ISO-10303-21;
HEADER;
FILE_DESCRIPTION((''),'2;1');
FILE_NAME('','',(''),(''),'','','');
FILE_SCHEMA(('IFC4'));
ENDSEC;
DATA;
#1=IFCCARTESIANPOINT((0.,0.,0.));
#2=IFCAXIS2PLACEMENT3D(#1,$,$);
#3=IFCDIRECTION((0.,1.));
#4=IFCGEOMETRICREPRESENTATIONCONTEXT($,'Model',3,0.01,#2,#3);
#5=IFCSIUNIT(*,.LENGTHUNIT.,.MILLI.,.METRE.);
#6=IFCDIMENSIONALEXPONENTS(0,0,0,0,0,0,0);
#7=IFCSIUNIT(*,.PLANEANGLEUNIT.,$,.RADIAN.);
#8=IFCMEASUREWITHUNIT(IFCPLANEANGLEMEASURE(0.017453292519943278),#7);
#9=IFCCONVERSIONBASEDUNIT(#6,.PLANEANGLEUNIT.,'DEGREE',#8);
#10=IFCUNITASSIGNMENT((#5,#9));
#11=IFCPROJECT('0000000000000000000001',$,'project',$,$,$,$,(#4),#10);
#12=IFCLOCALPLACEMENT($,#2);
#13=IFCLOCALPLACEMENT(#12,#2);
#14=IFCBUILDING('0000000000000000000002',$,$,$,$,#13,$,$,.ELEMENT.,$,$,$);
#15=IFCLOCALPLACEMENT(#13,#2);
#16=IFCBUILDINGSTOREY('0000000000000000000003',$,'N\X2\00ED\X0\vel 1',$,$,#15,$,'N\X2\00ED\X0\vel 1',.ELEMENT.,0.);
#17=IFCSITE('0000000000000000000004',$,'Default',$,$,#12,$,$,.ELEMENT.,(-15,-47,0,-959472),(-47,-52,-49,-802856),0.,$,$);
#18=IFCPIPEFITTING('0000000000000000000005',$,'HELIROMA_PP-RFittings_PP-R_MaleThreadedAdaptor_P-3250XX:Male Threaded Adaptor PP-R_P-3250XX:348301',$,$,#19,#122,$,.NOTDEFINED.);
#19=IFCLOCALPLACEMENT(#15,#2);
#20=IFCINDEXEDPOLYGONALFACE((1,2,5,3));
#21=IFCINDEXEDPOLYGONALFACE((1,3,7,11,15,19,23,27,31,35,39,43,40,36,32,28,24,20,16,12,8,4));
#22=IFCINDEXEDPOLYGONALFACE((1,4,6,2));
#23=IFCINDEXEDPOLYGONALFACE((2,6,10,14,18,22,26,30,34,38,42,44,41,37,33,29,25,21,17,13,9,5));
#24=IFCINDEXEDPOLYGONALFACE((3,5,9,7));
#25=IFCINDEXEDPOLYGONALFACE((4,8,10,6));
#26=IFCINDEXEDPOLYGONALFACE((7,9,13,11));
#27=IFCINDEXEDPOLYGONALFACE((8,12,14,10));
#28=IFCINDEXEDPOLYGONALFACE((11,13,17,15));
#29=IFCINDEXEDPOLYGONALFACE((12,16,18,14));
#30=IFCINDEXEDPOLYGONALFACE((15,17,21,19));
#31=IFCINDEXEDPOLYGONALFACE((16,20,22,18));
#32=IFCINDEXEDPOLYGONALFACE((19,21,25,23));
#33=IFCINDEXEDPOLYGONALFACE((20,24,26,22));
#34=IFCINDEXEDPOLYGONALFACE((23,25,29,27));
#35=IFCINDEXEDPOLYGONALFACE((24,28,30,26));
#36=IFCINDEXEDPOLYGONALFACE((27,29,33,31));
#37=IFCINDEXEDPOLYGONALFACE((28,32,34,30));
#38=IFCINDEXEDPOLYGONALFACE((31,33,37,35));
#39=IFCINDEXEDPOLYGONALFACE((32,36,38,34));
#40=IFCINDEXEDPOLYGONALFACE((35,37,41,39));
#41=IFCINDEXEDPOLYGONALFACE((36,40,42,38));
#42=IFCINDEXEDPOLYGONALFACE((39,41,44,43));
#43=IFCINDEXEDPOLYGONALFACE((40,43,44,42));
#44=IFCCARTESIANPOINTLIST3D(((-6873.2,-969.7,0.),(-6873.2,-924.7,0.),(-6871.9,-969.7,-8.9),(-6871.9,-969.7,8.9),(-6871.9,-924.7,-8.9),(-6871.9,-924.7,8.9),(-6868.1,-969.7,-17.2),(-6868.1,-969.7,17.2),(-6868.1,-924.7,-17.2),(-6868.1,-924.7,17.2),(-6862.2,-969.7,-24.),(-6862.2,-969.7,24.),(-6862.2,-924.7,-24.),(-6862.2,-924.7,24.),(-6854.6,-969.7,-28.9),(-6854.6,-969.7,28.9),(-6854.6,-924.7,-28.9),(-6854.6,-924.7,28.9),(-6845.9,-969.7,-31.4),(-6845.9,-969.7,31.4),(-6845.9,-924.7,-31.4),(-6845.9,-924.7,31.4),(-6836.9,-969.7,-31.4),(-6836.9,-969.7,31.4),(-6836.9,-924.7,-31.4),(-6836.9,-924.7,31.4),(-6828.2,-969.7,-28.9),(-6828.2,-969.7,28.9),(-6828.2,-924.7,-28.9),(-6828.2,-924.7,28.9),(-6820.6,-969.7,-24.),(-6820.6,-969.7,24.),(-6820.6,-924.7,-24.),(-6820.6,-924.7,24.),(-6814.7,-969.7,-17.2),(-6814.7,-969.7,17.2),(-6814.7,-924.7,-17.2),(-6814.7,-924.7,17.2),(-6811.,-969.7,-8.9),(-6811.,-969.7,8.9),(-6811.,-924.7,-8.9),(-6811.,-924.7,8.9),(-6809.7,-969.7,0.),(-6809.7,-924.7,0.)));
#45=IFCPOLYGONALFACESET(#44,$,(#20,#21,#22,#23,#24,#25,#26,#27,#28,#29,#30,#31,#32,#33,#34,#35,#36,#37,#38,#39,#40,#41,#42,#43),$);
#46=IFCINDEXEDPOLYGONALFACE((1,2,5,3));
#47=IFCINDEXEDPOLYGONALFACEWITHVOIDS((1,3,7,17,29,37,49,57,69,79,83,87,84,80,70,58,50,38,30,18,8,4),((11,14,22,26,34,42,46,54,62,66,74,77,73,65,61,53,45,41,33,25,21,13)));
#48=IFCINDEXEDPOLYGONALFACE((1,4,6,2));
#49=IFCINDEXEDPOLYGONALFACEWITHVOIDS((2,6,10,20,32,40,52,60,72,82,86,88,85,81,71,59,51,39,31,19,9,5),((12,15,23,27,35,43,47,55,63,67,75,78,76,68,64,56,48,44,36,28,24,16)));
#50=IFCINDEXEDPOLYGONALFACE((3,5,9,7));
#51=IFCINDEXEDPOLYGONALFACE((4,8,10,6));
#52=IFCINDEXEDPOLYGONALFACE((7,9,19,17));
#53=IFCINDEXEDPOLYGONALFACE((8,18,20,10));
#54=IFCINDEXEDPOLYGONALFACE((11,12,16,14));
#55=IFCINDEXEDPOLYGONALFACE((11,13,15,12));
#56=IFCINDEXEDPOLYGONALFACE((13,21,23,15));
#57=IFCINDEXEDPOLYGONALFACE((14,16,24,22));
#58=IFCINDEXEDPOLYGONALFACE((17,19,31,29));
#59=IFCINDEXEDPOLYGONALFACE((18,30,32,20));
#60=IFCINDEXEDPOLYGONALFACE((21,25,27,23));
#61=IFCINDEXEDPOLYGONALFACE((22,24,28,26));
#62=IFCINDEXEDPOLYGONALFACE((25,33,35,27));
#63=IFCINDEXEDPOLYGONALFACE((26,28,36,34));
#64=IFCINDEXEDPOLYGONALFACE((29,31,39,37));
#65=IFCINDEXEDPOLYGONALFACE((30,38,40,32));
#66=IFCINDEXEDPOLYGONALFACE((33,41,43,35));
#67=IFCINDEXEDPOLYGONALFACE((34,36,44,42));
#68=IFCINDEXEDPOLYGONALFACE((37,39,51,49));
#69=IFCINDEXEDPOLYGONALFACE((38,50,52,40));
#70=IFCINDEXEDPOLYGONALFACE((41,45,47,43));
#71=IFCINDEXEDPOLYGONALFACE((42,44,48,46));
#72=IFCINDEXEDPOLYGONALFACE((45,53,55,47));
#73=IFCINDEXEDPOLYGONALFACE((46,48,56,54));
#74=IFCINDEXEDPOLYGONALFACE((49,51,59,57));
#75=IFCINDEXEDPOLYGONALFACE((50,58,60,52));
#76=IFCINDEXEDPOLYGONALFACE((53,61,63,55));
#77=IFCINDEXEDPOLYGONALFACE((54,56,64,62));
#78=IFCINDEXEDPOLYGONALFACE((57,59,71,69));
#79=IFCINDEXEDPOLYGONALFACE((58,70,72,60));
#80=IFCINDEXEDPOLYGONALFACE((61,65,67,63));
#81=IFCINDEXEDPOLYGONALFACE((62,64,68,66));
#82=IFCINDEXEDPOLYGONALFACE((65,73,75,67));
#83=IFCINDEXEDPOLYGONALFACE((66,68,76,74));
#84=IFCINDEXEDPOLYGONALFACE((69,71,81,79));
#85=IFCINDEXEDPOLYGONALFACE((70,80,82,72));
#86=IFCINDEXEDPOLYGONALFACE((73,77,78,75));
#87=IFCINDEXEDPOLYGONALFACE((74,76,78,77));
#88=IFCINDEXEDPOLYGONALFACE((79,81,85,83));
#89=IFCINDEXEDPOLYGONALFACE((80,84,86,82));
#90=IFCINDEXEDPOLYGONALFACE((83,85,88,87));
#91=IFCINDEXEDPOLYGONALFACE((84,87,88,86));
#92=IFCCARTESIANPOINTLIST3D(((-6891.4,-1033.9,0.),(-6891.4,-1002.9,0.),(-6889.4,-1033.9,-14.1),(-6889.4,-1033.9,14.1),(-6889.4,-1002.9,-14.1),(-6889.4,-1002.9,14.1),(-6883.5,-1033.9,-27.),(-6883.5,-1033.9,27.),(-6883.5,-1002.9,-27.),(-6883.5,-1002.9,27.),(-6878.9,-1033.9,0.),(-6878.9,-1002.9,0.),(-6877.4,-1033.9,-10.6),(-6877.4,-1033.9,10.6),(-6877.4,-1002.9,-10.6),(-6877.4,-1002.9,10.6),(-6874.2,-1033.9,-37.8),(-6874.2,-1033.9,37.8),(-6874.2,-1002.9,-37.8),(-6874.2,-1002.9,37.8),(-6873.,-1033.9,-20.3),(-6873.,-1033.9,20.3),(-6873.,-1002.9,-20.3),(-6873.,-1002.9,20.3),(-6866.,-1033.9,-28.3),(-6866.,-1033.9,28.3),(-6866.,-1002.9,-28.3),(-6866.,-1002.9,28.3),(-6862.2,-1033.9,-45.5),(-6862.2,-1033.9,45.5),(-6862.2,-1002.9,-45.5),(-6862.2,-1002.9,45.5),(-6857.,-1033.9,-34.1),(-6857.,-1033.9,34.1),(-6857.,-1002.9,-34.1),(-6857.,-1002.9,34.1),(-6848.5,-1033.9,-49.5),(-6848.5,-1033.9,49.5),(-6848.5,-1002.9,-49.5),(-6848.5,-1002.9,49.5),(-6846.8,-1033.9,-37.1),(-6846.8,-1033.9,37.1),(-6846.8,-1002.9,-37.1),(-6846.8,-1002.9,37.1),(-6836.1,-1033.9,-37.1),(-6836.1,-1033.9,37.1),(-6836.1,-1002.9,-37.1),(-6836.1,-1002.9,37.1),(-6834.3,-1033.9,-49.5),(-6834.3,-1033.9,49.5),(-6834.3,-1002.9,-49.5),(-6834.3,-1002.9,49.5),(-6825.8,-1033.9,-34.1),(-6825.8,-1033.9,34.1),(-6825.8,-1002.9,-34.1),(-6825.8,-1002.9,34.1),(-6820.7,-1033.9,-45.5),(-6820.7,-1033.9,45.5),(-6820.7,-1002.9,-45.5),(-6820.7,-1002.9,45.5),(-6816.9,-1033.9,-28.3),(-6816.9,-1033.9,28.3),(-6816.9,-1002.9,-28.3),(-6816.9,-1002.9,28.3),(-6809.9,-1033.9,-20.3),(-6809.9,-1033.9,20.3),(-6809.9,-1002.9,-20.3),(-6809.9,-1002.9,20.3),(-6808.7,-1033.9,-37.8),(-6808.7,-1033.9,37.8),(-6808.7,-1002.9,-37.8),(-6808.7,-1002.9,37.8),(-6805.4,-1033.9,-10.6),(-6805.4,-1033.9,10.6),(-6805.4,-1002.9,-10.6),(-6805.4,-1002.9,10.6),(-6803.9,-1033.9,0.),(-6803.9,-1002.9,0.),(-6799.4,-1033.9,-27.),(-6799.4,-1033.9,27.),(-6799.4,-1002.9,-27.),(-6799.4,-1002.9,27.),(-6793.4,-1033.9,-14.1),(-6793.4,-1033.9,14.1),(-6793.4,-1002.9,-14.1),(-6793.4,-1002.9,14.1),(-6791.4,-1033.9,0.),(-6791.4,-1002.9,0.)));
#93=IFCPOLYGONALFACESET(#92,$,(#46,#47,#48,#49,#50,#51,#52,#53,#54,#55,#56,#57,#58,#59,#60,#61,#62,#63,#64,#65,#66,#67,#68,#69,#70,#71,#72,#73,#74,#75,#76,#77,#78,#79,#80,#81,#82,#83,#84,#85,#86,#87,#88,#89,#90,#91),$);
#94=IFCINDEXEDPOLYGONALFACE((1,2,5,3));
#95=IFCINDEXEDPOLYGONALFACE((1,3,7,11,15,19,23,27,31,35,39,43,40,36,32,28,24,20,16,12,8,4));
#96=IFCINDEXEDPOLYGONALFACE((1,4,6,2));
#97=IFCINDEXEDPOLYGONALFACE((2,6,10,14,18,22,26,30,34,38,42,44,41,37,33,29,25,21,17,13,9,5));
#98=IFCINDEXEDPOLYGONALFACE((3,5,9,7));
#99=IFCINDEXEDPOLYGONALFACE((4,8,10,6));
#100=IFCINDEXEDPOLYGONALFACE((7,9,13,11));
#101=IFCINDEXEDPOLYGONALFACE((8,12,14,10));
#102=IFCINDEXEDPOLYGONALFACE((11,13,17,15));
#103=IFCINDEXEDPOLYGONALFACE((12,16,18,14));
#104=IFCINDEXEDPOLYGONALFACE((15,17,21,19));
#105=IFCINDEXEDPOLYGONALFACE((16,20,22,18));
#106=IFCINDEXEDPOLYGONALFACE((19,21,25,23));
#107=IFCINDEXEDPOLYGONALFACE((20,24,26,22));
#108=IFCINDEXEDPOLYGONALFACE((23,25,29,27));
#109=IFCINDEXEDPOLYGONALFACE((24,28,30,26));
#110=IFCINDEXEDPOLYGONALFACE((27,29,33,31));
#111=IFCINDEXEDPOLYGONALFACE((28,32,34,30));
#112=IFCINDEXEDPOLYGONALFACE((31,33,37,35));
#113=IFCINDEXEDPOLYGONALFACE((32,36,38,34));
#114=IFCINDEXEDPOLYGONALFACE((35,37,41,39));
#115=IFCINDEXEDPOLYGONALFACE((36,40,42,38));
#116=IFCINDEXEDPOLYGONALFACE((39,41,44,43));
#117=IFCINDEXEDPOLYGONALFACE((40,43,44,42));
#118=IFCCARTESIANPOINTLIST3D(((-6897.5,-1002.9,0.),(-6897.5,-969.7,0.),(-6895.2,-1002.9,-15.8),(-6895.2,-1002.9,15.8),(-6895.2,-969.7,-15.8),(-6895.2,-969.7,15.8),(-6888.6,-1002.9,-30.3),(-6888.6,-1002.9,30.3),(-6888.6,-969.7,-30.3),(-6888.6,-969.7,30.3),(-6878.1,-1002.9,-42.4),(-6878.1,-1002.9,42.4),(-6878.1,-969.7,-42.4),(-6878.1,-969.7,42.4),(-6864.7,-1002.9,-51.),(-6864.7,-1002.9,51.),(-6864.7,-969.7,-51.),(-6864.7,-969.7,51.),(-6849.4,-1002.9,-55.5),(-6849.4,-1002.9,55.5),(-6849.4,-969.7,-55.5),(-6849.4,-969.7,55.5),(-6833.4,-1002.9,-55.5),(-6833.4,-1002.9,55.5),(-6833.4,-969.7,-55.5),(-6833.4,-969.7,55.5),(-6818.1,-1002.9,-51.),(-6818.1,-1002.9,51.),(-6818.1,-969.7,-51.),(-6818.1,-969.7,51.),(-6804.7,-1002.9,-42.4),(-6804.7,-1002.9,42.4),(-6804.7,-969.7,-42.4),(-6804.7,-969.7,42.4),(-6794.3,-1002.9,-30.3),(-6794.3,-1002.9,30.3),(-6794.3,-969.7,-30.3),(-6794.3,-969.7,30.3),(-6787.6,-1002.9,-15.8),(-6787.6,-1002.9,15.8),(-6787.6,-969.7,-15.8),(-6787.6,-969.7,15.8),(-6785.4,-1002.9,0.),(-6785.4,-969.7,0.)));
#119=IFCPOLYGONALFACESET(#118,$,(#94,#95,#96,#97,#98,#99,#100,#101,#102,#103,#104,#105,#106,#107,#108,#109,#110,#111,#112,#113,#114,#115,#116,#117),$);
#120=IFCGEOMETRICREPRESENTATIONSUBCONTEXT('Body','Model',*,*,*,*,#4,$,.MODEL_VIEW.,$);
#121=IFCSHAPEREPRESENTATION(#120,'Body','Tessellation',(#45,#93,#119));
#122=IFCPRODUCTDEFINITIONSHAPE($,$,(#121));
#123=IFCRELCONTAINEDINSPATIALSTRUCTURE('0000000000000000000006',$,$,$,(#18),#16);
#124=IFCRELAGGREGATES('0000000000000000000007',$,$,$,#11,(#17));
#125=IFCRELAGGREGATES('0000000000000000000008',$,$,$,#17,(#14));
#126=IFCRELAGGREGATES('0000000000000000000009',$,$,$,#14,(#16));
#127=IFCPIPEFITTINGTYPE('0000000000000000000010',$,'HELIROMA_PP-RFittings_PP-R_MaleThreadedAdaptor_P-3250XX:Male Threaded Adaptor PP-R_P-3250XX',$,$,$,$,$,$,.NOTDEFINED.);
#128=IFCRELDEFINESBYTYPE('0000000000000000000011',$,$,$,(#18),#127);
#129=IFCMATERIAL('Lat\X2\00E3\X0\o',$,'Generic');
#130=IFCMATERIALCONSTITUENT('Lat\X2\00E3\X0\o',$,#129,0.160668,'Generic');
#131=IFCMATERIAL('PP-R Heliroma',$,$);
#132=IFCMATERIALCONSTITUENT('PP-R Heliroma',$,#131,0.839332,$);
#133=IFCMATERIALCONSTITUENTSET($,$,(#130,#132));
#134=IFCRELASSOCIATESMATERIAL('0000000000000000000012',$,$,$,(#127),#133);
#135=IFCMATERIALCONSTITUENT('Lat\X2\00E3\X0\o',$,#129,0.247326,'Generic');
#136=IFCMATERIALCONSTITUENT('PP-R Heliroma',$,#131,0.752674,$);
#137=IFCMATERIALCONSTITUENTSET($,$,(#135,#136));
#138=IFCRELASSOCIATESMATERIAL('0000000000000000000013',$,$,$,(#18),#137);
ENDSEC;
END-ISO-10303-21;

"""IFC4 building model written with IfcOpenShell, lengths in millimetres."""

from ifc_helpers import new_model, entity, si_unit, converted_unit, direction, frame, origin, place, context, subcontext, project, spatial, arc, indexed_curve, outline, extrude, source, transform, mapped, material, constituent, constituent_set, type_object, type_shapes, element, save


model = new_model("IFC4")

# Units and contexts
model_context = context("Model", 3, precision=0.01, world=origin(), true_north=direction((0.0, 1.0)))
body_context = subcontext(model_context, "Body", "Model", "MODEL_VIEW")
ifc_project = project(units=[si_unit("LENGTHUNIT", "METRE", prefix="MILLI"), converted_unit("PLANEANGLEUNIT", "DEGREE", entity("IfcPlaneAngleMeasure", 0.017453292519943278), si_unit("PLANEANGLEUNIT", "RADIAN"), dimensions=[0, 0, 0, 0, 0, 0, 0])], contexts=[model_context])

# Site, building, storey
site_placement = place(None, origin())
site = spatial("IfcSite", under=ifc_project, at=site_placement, Name="Default", CompositionType="ELEMENT", RefLatitude=(-15, -47, 0, -959472), RefLongitude=(-47, -52, -49, -802856), RefElevation=0.0)
building_placement = place(site_placement, origin())
building = spatial("IfcBuilding", under=site, at=building_placement, CompositionType="ELEMENT")
storey_placement = place(building_placement, origin())
storey = spatial("IfcBuildingStorey", under=building, at=storey_placement, Name="Nível 1", LongName="Nível 1", CompositionType="ELEMENT", Elevation=0.0)

# Shared definitions
ifc_material_1 = material(Name="PP-R Heliroma")

# Pipe fitting
ifc_material_2 = material(Name="Latão", Category="Generic")
ifc_constituent_1 = constituent(ifc_material_2, Name="Latão", Category="Generic", fraction=0.247326)
ifc_constituent_2 = constituent(ifc_material_1, Name="PP-R Heliroma", fraction=0.752674)
ifc_constituent_set_1 = constituent_set(constituents=[ifc_constituent_1, ifc_constituent_2])
ifc_constituent_3 = constituent(ifc_material_2, Name="Latão", Category="Generic", fraction=0.160668)
ifc_constituent_4 = constituent(ifc_material_1, Name="PP-R Heliroma", fraction=0.839332)
ifc_constituent_set_2 = constituent_set(constituents=[ifc_constituent_3, ifc_constituent_4])
pipe_fitting_type_1 = type_object("IfcPipeFittingType", Name="HELIROMA_PP-RFittings_PP-R_MaleThreadedAdaptor_P-3250XX:Male Threaded Adaptor PP-R_P-3250XX", PredefinedType="NOTDEFINED", material=ifc_constituent_set_2)
shared_shape_1 = source(origin(), body_context, "Body", "SweptSolid", [
    extrude(outline(indexed_curve([(-31.8, 0.0), (0.0, -31.8), (31.8, 0.0), (0.0, 31.7)], segments=[arc(1, 2, 3), arc(3, 4, 1)], self_intersect=False)), frame((0.0, 33.2, 0.0), z_axis=(0.0, 1.0, 0.0), x_axis=(1.0, 0.0, 0.0)), (0.0, 0.0, 1.0), 45.0),
    extrude(outline(indexed_curve([(-50.0, 0.0), (0.0, -50.0), (50.0, 0.0), (0.0, 50.0)], segments=[arc(1, 2, 3), arc(3, 4, 1)], self_intersect=False), holes=[indexed_curve([(-37.5, 0.0), (0.0, 37.5), (37.5, 0.0), (0.0, -37.5)], segments=[arc(1, 2, 3), arc(3, 4, 1)], self_intersect=False)]), frame((0.0, -31.0, 0.0), z_axis=(0.0, 1.0, 0.0), x_axis=(1.0, 0.0, 0.0)), (0.0, 0.0, 1.0), 31.0),
    extrude(outline(indexed_curve([(-56.0, 0.0), (0.0, -56.1), (56.0, 0.0), (0.0, 56.0)], segments=[arc(1, 2, 3), arc(3, 4, 1)], self_intersect=False)), frame((0.0, 0.0, 0.0), z_axis=(0.0, 1.0, 0.0), x_axis=(1.0, 0.0, 0.0)), (0.0, 0.0, 1.0), 33.2),
])
type_shapes(pipe_fitting_type_1, [shared_shape_1])
pipe_fitting_1_placement = place(storey_placement, frame((-6841.4, -1002.9, 0.0), z_axis=(0.0, 0.0, -1.0), x_axis=(-1.0, 0.0, 0.0)))
element("IfcPipeFitting", 1, at=pipe_fitting_1_placement, inside=storey, type_object=pipe_fitting_type_1, material=ifc_constituent_set_1, Name="HELIROMA_PP-RFittings_PP-R_MaleThreadedAdaptor_P-3250XX:Male Threaded Adaptor PP-R_P-3250XX:348301", PredefinedType="NOTDEFINED", context=body_context, shape_type="MappedRepresentation", body=[
    mapped(shared_shape_1, transform((0.0, 0.0, 0.0), scale=1.0)),
])

save(model, "model.ifc")
